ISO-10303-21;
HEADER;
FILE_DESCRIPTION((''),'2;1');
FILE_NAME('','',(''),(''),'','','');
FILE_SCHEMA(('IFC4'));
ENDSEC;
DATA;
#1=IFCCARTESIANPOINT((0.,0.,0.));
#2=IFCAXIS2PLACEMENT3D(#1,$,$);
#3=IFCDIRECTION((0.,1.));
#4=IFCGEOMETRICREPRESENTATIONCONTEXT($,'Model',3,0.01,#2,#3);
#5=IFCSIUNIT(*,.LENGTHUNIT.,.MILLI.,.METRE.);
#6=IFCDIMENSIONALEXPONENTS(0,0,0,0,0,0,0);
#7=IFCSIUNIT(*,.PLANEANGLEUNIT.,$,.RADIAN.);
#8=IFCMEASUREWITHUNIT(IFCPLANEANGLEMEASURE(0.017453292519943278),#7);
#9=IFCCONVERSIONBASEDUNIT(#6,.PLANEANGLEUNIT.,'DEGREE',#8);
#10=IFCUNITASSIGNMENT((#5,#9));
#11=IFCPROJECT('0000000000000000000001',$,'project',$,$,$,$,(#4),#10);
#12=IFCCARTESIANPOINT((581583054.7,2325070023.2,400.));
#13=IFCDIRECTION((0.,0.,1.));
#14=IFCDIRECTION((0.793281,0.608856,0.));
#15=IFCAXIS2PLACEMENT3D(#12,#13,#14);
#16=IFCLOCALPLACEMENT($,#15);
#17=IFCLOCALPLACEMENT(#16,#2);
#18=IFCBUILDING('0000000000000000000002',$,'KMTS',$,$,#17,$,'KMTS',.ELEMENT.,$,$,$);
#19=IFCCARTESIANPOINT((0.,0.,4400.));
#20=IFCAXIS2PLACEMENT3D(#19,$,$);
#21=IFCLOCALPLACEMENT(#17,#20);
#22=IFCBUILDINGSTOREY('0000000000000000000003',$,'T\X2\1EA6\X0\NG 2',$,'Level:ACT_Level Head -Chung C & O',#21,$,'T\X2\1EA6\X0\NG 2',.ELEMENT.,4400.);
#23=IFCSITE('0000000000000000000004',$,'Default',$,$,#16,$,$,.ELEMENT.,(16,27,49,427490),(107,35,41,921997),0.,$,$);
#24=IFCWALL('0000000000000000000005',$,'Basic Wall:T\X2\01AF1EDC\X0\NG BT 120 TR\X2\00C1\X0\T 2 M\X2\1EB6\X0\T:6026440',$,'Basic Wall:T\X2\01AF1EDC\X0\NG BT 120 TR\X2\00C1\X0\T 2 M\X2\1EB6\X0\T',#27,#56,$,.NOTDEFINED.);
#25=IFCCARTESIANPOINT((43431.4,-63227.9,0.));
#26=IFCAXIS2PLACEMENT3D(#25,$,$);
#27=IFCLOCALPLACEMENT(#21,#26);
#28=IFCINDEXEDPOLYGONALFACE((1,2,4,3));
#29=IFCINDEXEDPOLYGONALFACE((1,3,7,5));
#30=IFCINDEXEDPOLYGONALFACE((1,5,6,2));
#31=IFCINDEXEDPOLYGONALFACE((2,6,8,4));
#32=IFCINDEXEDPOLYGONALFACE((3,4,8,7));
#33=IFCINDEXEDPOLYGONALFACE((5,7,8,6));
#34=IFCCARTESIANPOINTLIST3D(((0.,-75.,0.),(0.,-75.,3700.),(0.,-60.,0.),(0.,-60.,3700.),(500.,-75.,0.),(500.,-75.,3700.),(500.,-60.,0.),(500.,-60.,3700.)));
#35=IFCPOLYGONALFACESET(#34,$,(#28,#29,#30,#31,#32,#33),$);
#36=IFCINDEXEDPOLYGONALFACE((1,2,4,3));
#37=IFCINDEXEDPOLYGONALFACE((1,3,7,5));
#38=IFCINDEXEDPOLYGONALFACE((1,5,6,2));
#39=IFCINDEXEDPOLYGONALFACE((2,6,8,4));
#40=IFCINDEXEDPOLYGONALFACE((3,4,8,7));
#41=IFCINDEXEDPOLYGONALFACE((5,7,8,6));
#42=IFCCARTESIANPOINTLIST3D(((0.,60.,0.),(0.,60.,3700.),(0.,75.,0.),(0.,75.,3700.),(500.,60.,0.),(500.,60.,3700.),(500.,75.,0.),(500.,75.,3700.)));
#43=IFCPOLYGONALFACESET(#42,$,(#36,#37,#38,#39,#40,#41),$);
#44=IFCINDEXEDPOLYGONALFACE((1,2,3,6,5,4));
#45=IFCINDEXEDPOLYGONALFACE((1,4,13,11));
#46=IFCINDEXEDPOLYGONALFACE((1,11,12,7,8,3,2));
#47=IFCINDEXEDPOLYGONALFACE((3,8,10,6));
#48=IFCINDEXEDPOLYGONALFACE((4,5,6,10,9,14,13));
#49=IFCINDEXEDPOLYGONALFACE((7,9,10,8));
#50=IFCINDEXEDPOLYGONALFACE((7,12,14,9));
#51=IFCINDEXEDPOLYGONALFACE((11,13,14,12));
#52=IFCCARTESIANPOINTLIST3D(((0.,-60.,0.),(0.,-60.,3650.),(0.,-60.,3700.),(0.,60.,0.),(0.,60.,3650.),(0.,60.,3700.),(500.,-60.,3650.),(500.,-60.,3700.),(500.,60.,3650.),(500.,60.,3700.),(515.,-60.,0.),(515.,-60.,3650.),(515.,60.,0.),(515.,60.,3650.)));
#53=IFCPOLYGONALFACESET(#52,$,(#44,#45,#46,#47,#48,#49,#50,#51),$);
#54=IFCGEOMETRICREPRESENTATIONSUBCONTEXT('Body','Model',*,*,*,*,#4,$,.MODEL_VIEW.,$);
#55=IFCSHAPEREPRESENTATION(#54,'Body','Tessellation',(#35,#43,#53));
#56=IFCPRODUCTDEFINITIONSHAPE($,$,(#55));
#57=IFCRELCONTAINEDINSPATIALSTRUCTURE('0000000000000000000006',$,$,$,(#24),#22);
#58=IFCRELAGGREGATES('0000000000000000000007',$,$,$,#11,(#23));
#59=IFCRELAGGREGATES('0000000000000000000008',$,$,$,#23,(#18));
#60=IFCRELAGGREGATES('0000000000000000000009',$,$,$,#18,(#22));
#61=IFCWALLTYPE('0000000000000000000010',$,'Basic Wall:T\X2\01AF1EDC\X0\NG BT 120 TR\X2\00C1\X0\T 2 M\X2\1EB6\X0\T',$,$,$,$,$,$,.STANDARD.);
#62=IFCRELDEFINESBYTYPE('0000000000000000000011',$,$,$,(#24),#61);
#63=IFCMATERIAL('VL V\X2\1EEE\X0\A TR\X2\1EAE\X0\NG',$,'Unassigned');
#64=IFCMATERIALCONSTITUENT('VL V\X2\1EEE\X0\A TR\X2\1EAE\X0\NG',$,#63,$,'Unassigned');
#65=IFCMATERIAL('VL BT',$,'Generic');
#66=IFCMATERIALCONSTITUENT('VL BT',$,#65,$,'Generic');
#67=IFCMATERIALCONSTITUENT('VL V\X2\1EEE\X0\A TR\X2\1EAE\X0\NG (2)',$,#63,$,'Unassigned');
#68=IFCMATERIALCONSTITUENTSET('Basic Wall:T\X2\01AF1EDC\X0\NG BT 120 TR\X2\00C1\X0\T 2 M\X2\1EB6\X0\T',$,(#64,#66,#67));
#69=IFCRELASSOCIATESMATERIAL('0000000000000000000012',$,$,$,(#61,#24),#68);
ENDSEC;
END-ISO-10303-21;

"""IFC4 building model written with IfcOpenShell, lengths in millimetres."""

from ifc_helpers import new_model, entity, si_unit, converted_unit, direction, frame, origin, place, context, subcontext, project, spatial, indexed_curve, outline, extrude, material, constituent, constituent_set, type_object, element, save


model = new_model("IFC4")

# Units and contexts
model_context = context("Model", 3, precision=0.01, world=origin(), true_north=direction((0.0, 1.0)))
body_context = subcontext(model_context, "Body", "Model", "MODEL_VIEW")
ifc_project = project(units=[si_unit("LENGTHUNIT", "METRE", prefix="MILLI"), converted_unit("PLANEANGLEUNIT", "DEGREE", entity("IfcPlaneAngleMeasure", 0.017453292519943278), si_unit("PLANEANGLEUNIT", "RADIAN"), dimensions=[0, 0, 0, 0, 0, 0, 0])], contexts=[model_context])

# Site, building, storey
site_placement = place(None, frame((581583054.7, 2325070023.2, 400.0), z_axis=(0.0, 0.0, 1.0), x_axis=(0.793281, 0.608856, 0.0)))
site = spatial("IfcSite", under=ifc_project, at=site_placement, Name="Default", CompositionType="ELEMENT", RefLatitude=(16, 27, 49, 427490), RefLongitude=(107, 35, 41, 921997), RefElevation=0.0)
building_placement = place(site_placement, origin())
building = spatial("IfcBuilding", under=site, at=building_placement, Name="KMTS", LongName="KMTS", CompositionType="ELEMENT")
storey_placement = place(building_placement, frame((0.0, 0.0, 4400.0)))
storey = spatial("IfcBuildingStorey", under=building, at=storey_placement, Name="TẦNG 2", ObjectType="Level:ACT_Level Head -Chung C & O", LongName="TẦNG 2", CompositionType="ELEMENT", Elevation=4400.0)

# Shared definitions
ifc_material_1 = material(Name="VL VỮA TRẮNG", Category="Unassigned")
ifc_material_2 = material(Name="VL BT", Category="Generic")

# Shared definitions
ifc_constituent_1 = constituent(ifc_material_1, Name="VL VỮA TRẮNG", Category="Unassigned")
ifc_constituent_2 = constituent(ifc_material_2, Name="VL BT", Category="Generic")
ifc_constituent_3 = constituent(ifc_material_1, Name="VL VỮA TRẮNG (2)", Category="Unassigned")
ifc_constituent_set_1 = constituent_set(constituents=[ifc_constituent_1, ifc_constituent_2, ifc_constituent_3], Name="Basic Wall:TƯỜNG BT 120 TRÁT 2 MẶT")
wall_type_1 = type_object("IfcWallType", Name="Basic Wall:TƯỜNG BT 120 TRÁT 2 MẶT", PredefinedType="STANDARD", material=ifc_constituent_set_1)

# Wall
wall_1_placement = place(storey_placement, frame((43431.4, -63227.9, 0.0)))
element("IfcWall", 1, at=wall_1_placement, inside=storey, type_object=wall_type_1, material=ifc_constituent_set_1, Name="Basic Wall:TƯỜNG BT 120 TRÁT 2 MẶT:6026440", ObjectType="Basic Wall:TƯỜNG BT 120 TRÁT 2 MẶT", PredefinedType="NOTDEFINED", context=body_context, shape_type="SweptSolid", body=[
    extrude(outline(indexed_curve([(-7.5, -250.0), (7.5, -250.0), (7.5, 250.0), (-7.5, 250.0), (-7.5, -250.0)], self_intersect=False)), frame((250.0, -67.5, 0.0), z_axis=(0.0, 0.0, 1.0), x_axis=(0.0, 1.0, 0.0)), (0.0, 0.0, 1.0), 3700.0),
    extrude(outline(indexed_curve([(-7.5, -250.0), (7.5, -250.0), (7.5, 250.0), (-7.5, 250.0), (-7.5, -250.0)], self_intersect=False)), frame((250.0, 67.5, 0.0), z_axis=(0.0, 0.0, 1.0), x_axis=(0.0, -1.0, 0.0)), (0.0, 0.0, 1.0), 3700.0),
    extrude(outline(indexed_curve([(-2621.4, -290.0), (1028.6, -290.0), (1078.6, -290.0), (1078.6, 210.0), (1028.6, 210.0), (1028.6, 225.0), (-2621.4, 225.0), (-2621.4, -290.0)], self_intersect=False)), frame((290.0, -60.0, 2621.4), z_axis=(0.0, 1.0, 0.0), x_axis=(0.0, 0.0, 1.0)), (0.0, 0.0, 1.0), 120.0),
])

save(model, "model.ifc")
